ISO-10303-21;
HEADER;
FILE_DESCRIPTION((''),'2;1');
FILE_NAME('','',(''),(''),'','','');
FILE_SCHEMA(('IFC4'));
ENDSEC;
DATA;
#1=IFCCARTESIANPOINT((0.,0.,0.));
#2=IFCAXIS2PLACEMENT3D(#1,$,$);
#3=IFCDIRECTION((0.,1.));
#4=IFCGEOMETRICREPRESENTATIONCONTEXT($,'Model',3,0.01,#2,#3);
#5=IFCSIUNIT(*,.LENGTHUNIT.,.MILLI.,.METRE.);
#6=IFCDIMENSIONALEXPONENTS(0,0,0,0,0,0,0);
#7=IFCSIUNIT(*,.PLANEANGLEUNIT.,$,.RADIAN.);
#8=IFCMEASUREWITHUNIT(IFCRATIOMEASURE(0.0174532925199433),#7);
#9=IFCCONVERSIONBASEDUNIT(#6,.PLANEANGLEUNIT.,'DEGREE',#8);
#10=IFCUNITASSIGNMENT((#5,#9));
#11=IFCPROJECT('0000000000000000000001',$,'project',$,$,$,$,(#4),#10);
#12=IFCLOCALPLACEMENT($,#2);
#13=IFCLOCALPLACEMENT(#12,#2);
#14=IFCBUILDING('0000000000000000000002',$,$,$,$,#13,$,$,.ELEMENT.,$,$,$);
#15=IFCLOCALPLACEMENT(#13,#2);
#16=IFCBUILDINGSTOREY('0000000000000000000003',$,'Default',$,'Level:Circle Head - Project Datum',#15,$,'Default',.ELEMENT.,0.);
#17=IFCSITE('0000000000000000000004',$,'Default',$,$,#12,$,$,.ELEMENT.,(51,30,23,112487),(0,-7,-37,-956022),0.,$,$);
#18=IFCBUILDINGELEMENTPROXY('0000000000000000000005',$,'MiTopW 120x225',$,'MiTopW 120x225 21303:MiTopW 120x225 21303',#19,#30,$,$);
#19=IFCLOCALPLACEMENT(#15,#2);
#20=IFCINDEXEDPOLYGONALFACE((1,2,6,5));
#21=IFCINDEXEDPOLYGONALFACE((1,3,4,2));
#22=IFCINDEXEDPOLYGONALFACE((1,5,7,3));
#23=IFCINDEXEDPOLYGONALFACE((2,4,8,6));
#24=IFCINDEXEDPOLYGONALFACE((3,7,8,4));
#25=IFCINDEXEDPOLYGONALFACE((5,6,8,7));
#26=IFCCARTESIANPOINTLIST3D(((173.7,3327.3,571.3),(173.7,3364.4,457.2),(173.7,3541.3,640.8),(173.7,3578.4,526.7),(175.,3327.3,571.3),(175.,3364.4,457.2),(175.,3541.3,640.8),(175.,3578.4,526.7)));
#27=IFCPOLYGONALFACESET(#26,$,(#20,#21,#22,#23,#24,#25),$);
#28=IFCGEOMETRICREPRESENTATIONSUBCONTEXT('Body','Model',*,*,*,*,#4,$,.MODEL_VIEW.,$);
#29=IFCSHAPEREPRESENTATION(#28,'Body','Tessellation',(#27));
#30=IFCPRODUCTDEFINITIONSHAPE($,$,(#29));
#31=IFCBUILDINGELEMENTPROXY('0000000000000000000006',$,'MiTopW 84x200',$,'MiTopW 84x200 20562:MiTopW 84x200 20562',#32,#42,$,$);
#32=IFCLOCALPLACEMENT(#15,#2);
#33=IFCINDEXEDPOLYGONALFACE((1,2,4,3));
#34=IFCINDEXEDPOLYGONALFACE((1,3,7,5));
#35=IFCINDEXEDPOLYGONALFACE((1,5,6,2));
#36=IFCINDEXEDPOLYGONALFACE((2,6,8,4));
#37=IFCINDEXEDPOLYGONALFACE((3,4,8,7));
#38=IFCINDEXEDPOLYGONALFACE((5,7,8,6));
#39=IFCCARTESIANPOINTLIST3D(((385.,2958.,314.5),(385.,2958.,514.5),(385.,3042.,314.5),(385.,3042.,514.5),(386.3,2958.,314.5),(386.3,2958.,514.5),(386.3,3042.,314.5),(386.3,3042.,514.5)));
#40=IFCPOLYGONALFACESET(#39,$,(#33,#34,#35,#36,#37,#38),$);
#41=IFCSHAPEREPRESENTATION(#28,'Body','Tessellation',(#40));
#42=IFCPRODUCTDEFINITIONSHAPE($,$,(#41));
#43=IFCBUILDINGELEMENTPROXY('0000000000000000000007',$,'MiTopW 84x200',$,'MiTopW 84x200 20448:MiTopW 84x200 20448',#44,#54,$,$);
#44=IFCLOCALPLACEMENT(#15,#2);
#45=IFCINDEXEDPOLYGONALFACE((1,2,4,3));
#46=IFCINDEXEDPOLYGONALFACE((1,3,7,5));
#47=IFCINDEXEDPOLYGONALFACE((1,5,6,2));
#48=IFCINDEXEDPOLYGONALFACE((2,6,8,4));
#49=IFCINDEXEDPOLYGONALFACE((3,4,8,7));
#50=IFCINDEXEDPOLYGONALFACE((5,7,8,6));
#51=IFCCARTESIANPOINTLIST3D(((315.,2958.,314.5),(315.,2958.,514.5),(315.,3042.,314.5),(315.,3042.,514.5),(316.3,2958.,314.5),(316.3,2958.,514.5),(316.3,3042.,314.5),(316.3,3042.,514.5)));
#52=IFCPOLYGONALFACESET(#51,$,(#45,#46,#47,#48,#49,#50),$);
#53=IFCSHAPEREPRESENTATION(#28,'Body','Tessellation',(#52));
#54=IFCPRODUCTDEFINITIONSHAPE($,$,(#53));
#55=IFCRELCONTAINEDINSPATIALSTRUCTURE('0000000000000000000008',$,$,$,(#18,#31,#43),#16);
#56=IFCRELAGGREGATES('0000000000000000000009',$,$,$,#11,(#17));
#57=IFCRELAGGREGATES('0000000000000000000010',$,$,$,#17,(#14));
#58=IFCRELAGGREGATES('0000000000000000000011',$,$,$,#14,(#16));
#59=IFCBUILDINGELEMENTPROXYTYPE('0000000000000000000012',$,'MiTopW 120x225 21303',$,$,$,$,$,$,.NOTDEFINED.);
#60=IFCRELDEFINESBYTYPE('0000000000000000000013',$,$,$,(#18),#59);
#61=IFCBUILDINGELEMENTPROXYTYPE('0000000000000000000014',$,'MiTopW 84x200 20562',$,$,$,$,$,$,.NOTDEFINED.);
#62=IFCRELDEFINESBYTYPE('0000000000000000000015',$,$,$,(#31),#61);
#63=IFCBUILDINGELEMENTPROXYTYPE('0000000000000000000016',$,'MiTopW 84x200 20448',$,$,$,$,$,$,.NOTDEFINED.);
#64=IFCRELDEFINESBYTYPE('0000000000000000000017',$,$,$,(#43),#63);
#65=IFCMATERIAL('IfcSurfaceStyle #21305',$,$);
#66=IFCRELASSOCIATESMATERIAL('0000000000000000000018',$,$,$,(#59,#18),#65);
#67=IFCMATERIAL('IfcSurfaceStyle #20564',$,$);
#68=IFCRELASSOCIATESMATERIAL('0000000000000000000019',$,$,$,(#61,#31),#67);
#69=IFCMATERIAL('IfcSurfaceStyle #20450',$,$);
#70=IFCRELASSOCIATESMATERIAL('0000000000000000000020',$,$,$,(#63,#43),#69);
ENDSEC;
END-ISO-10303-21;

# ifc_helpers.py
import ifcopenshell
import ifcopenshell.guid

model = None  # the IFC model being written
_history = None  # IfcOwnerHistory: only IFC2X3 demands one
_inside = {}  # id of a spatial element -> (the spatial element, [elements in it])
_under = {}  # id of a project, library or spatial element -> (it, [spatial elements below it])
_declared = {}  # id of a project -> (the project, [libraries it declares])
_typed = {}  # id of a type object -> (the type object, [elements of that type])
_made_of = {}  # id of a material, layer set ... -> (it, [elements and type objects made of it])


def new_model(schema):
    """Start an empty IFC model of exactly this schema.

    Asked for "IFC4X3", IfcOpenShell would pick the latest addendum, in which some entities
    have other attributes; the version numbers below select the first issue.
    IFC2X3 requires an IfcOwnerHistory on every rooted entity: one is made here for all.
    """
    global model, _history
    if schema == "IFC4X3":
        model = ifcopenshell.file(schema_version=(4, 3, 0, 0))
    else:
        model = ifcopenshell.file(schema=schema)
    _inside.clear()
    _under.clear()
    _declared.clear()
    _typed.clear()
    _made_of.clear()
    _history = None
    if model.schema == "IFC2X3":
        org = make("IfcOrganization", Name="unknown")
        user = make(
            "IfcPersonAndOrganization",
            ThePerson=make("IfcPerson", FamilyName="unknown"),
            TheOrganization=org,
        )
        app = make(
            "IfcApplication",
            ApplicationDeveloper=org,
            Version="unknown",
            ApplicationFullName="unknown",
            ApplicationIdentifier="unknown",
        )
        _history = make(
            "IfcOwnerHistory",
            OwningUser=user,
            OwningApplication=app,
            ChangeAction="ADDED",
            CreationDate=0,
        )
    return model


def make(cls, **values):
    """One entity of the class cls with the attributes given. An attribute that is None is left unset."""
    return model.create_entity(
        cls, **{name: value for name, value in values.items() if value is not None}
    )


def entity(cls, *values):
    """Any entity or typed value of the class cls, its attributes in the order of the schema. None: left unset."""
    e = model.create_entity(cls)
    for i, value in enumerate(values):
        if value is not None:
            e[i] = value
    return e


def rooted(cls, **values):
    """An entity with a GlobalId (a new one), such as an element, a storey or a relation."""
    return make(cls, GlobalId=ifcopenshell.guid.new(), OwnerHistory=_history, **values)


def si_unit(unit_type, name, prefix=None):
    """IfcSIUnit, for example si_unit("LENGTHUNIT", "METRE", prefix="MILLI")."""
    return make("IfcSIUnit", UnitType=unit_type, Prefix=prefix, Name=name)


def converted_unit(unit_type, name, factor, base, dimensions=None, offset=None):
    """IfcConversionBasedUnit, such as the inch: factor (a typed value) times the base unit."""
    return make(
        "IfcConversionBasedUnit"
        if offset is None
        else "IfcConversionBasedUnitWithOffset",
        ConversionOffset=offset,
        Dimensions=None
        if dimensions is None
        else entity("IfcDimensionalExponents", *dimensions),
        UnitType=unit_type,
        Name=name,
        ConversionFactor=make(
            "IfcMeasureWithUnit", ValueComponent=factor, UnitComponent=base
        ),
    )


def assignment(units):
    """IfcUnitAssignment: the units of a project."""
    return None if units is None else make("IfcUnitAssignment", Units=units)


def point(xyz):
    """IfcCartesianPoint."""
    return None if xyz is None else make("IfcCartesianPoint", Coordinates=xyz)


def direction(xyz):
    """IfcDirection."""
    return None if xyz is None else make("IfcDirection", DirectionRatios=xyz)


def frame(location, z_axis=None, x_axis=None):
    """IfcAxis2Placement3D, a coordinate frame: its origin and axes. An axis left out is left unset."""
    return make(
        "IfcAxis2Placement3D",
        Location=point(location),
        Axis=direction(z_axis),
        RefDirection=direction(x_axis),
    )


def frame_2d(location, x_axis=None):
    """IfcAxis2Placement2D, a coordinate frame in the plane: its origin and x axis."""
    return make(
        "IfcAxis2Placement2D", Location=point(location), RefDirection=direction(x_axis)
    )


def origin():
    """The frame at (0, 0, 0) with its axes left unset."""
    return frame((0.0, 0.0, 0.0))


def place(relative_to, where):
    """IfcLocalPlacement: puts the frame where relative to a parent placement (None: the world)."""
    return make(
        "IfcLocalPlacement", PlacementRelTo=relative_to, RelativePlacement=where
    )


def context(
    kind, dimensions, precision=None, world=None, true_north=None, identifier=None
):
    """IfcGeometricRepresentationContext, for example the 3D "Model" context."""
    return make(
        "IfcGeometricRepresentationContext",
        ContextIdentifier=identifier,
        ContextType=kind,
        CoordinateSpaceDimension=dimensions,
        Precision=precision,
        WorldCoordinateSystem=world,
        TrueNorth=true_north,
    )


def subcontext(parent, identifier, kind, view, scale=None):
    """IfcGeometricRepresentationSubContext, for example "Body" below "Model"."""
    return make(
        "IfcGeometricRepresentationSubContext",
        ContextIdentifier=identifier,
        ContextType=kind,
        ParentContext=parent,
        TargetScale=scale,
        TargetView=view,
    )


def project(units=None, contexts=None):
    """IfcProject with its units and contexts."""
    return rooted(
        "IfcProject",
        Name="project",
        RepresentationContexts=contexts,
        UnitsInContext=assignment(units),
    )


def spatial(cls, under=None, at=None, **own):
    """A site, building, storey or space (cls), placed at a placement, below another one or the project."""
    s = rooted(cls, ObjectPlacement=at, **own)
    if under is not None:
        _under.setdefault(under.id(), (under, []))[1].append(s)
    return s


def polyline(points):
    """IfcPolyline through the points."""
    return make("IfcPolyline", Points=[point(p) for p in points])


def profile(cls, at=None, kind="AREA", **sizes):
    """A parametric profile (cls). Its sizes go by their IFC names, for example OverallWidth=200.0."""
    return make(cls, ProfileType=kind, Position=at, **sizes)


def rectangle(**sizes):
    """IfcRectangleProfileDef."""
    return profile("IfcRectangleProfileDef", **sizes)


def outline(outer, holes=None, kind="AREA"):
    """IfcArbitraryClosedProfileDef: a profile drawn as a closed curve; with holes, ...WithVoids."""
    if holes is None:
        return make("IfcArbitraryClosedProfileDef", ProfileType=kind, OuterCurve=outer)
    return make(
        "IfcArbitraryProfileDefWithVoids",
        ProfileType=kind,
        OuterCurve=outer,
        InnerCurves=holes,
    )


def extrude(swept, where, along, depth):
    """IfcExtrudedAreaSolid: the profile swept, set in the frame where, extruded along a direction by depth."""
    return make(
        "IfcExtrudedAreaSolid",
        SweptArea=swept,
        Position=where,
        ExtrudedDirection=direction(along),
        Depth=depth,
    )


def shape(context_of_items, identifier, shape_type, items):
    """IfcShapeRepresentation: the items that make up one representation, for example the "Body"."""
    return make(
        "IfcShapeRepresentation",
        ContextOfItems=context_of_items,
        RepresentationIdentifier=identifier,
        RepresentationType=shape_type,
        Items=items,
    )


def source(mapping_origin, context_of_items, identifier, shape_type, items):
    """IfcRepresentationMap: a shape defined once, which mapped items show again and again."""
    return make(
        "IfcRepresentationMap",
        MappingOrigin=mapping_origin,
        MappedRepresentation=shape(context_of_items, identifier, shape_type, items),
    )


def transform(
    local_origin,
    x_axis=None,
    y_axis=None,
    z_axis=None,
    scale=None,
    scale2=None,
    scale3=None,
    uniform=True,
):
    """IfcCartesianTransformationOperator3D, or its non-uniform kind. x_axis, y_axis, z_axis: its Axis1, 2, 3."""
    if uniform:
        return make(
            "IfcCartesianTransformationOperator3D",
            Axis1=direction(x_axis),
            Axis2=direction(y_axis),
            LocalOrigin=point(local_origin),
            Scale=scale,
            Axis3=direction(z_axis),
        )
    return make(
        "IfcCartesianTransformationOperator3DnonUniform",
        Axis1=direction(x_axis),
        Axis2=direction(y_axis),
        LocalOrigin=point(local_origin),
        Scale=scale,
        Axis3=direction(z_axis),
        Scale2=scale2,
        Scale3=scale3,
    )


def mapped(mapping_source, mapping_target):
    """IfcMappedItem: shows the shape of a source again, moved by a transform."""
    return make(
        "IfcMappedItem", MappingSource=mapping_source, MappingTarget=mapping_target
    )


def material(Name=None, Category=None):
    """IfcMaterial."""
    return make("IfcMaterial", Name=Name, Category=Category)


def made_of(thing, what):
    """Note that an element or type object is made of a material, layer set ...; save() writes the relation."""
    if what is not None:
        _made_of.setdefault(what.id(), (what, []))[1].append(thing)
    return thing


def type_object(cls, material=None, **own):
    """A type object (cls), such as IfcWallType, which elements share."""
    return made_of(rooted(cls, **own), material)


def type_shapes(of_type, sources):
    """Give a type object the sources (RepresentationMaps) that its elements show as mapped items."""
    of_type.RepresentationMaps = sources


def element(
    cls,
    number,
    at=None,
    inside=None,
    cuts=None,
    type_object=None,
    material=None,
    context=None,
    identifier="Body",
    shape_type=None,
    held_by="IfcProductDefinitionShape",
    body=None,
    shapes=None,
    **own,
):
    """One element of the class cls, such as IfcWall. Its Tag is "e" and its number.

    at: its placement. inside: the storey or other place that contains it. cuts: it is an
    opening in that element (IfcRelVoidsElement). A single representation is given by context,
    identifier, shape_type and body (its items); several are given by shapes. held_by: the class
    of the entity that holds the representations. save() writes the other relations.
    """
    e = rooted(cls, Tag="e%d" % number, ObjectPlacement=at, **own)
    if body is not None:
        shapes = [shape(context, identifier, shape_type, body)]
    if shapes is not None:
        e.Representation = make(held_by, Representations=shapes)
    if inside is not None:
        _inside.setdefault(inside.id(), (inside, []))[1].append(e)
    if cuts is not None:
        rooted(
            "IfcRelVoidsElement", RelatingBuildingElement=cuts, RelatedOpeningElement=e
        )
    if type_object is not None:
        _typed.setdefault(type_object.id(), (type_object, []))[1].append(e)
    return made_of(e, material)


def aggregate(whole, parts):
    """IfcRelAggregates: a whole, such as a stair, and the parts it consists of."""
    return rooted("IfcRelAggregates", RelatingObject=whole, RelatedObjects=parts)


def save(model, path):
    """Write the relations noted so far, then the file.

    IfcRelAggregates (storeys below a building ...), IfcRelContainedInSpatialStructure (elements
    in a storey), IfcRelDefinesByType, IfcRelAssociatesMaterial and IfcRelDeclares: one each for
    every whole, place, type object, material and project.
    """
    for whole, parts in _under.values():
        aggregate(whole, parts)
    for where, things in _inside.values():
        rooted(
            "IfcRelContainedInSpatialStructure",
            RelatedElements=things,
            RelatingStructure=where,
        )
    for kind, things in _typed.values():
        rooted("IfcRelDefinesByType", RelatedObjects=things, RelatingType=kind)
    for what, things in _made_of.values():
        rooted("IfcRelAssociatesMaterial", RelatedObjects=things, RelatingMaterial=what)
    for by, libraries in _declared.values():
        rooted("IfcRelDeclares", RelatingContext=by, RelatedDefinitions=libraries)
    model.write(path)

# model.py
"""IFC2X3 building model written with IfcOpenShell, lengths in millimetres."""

from ifc_helpers import new_model, entity, si_unit, converted_unit, direction, frame, frame_2d, origin, place, context, subcontext, project, spatial, polyline, rectangle, outline, extrude, source, transform, mapped, material, type_object, type_shapes, element, save


model = new_model("IFC2X3")

# Units and contexts
model_context = context("Model", 3, precision=0.01, world=origin(), true_north=direction((0.0, 1.0)))
body_context = subcontext(model_context, "Body", "Model", "MODEL_VIEW")
ifc_project = project(units=[si_unit("LENGTHUNIT", "METRE", prefix="MILLI"), converted_unit("PLANEANGLEUNIT", "DEGREE", entity("IfcRatioMeasure", 0.0174532925199433), si_unit("PLANEANGLEUNIT", "RADIAN"), dimensions=[0, 0, 0, 0, 0, 0, 0])], contexts=[model_context])

# Site, building, storey
site_placement = place(None, origin())
site = spatial("IfcSite", under=ifc_project, at=site_placement, Name="Default", CompositionType="ELEMENT", RefLatitude=(51, 30, 23, 112487), RefLongitude=(0, -7, -37, -956022), RefElevation=0.0)
building_placement = place(site_placement, origin())
building = spatial("IfcBuilding", under=site, at=building_placement, CompositionType="ELEMENT")
storey_placement = place(building_placement, origin())
storey = spatial("IfcBuildingStorey", under=building, at=storey_placement, Name="Default", ObjectType="Level:Circle Head - Project Datum", LongName="Default", CompositionType="ELEMENT", Elevation=0.0)

# Building element proxies
ifc_material_1 = material(Name="IfcSurfaceStyle #21305")
building_element_proxy_type_1 = type_object("IfcBuildingElementProxyType", Name="MiTopW 120x225 21303", PredefinedType="NOTDEFINED", material=ifc_material_1)
shared_shape_1 = source(origin(), body_context, "Body", "SweptSolid", [
    extrude(outline(polyline([(-112.5, -60.0), (112.5, -60.0), (112.5, 60.0), (-112.5, 60.0), (-112.5, -60.0)])), frame((112.5, 60.0, 0.0), z_axis=(0.0, 0.0, 1.0), x_axis=(-1.0, 0.0, 0.0)), (0.0, 0.0, 1.0), 1.3),
])
type_shapes(building_element_proxy_type_1, [shared_shape_1])
proxy_1_placement = place(building_placement, frame((175.0, 3327.3, 571.3), z_axis=(-1.0, 0.0, 0.0), x_axis=(0.0, 0.951057, 0.309017)))
element("IfcBuildingElementProxy", 1, at=proxy_1_placement, inside=storey, type_object=building_element_proxy_type_1, material=ifc_material_1, Name="MiTopW 120x225", ObjectType="MiTopW 120x225 21303:MiTopW 120x225 21303", context=body_context, shape_type="MappedRepresentation", body=[
    mapped(shared_shape_1, transform((0.0, 0.0, 0.0), scale=1.0)),
])
ifc_material_2 = material(Name="IfcSurfaceStyle #20564")
building_element_proxy_type_2 = type_object("IfcBuildingElementProxyType", Name="MiTopW 84x200 20562", PredefinedType="NOTDEFINED", material=ifc_material_2)
shared_shape_2 = source(origin(), body_context, "Body", "SweptSolid", [
    extrude(rectangle(XDim=200.0, YDim=84.0, at=frame_2d((0.0, 0.0), x_axis=(1.0, 0.0))), frame((100.0, 42.0, 0.0), z_axis=(0.0, 0.0, 1.0), x_axis=(-1.0, 0.0, 0.0)), (0.0, 0.0, 1.0), 1.3),
])
type_shapes(building_element_proxy_type_2, [shared_shape_2])
proxy_2_placement = place(building_placement, frame((386.3, 3042.0, 514.5), z_axis=(-1.0, 0.0, 0.0), x_axis=(0.0, 0.0, -1.0)))
element("IfcBuildingElementProxy", 2, at=proxy_2_placement, inside=storey, type_object=building_element_proxy_type_2, material=ifc_material_2, Name="MiTopW 84x200", ObjectType="MiTopW 84x200 20562:MiTopW 84x200 20562", context=body_context, shape_type="MappedRepresentation", body=[
    mapped(shared_shape_2, transform((0.0, 0.0, 0.0), scale=1.0)),
])
ifc_material_3 = material(Name="IfcSurfaceStyle #20450")
building_element_proxy_type_3 = type_object("IfcBuildingElementProxyType", Name="MiTopW 84x200 20448", PredefinedType="NOTDEFINED", material=ifc_material_3)
shared_shape_3 = source(origin(), body_context, "Body", "SweptSolid", [
    extrude(rectangle(XDim=200.0, YDim=84.0, at=frame_2d((0.0, 0.0), x_axis=(1.0, 0.0))), frame((100.0, 42.0, 0.0), z_axis=(0.0, 0.0, 1.0), x_axis=(-1.0, 0.0, 0.0)), (0.0, 0.0, 1.0), 1.3),
])
type_shapes(building_element_proxy_type_3, [shared_shape_3])
proxy_3_placement = place(building_placement, frame((316.3, 3042.0, 514.5), z_axis=(-1.0, 0.0, 0.0), x_axis=(0.0, 0.0, -1.0)))
element("IfcBuildingElementProxy", 3, at=proxy_3_placement, inside=storey, type_object=building_element_proxy_type_3, material=ifc_material_3, Name="MiTopW 84x200", ObjectType="MiTopW 84x200 20448:MiTopW 84x200 20448", context=body_context, shape_type="MappedRepresentation", body=[
    mapped(shared_shape_3, transform((0.0, 0.0, 0.0), scale=1.0)),
])

save(model, "model.ifc")
